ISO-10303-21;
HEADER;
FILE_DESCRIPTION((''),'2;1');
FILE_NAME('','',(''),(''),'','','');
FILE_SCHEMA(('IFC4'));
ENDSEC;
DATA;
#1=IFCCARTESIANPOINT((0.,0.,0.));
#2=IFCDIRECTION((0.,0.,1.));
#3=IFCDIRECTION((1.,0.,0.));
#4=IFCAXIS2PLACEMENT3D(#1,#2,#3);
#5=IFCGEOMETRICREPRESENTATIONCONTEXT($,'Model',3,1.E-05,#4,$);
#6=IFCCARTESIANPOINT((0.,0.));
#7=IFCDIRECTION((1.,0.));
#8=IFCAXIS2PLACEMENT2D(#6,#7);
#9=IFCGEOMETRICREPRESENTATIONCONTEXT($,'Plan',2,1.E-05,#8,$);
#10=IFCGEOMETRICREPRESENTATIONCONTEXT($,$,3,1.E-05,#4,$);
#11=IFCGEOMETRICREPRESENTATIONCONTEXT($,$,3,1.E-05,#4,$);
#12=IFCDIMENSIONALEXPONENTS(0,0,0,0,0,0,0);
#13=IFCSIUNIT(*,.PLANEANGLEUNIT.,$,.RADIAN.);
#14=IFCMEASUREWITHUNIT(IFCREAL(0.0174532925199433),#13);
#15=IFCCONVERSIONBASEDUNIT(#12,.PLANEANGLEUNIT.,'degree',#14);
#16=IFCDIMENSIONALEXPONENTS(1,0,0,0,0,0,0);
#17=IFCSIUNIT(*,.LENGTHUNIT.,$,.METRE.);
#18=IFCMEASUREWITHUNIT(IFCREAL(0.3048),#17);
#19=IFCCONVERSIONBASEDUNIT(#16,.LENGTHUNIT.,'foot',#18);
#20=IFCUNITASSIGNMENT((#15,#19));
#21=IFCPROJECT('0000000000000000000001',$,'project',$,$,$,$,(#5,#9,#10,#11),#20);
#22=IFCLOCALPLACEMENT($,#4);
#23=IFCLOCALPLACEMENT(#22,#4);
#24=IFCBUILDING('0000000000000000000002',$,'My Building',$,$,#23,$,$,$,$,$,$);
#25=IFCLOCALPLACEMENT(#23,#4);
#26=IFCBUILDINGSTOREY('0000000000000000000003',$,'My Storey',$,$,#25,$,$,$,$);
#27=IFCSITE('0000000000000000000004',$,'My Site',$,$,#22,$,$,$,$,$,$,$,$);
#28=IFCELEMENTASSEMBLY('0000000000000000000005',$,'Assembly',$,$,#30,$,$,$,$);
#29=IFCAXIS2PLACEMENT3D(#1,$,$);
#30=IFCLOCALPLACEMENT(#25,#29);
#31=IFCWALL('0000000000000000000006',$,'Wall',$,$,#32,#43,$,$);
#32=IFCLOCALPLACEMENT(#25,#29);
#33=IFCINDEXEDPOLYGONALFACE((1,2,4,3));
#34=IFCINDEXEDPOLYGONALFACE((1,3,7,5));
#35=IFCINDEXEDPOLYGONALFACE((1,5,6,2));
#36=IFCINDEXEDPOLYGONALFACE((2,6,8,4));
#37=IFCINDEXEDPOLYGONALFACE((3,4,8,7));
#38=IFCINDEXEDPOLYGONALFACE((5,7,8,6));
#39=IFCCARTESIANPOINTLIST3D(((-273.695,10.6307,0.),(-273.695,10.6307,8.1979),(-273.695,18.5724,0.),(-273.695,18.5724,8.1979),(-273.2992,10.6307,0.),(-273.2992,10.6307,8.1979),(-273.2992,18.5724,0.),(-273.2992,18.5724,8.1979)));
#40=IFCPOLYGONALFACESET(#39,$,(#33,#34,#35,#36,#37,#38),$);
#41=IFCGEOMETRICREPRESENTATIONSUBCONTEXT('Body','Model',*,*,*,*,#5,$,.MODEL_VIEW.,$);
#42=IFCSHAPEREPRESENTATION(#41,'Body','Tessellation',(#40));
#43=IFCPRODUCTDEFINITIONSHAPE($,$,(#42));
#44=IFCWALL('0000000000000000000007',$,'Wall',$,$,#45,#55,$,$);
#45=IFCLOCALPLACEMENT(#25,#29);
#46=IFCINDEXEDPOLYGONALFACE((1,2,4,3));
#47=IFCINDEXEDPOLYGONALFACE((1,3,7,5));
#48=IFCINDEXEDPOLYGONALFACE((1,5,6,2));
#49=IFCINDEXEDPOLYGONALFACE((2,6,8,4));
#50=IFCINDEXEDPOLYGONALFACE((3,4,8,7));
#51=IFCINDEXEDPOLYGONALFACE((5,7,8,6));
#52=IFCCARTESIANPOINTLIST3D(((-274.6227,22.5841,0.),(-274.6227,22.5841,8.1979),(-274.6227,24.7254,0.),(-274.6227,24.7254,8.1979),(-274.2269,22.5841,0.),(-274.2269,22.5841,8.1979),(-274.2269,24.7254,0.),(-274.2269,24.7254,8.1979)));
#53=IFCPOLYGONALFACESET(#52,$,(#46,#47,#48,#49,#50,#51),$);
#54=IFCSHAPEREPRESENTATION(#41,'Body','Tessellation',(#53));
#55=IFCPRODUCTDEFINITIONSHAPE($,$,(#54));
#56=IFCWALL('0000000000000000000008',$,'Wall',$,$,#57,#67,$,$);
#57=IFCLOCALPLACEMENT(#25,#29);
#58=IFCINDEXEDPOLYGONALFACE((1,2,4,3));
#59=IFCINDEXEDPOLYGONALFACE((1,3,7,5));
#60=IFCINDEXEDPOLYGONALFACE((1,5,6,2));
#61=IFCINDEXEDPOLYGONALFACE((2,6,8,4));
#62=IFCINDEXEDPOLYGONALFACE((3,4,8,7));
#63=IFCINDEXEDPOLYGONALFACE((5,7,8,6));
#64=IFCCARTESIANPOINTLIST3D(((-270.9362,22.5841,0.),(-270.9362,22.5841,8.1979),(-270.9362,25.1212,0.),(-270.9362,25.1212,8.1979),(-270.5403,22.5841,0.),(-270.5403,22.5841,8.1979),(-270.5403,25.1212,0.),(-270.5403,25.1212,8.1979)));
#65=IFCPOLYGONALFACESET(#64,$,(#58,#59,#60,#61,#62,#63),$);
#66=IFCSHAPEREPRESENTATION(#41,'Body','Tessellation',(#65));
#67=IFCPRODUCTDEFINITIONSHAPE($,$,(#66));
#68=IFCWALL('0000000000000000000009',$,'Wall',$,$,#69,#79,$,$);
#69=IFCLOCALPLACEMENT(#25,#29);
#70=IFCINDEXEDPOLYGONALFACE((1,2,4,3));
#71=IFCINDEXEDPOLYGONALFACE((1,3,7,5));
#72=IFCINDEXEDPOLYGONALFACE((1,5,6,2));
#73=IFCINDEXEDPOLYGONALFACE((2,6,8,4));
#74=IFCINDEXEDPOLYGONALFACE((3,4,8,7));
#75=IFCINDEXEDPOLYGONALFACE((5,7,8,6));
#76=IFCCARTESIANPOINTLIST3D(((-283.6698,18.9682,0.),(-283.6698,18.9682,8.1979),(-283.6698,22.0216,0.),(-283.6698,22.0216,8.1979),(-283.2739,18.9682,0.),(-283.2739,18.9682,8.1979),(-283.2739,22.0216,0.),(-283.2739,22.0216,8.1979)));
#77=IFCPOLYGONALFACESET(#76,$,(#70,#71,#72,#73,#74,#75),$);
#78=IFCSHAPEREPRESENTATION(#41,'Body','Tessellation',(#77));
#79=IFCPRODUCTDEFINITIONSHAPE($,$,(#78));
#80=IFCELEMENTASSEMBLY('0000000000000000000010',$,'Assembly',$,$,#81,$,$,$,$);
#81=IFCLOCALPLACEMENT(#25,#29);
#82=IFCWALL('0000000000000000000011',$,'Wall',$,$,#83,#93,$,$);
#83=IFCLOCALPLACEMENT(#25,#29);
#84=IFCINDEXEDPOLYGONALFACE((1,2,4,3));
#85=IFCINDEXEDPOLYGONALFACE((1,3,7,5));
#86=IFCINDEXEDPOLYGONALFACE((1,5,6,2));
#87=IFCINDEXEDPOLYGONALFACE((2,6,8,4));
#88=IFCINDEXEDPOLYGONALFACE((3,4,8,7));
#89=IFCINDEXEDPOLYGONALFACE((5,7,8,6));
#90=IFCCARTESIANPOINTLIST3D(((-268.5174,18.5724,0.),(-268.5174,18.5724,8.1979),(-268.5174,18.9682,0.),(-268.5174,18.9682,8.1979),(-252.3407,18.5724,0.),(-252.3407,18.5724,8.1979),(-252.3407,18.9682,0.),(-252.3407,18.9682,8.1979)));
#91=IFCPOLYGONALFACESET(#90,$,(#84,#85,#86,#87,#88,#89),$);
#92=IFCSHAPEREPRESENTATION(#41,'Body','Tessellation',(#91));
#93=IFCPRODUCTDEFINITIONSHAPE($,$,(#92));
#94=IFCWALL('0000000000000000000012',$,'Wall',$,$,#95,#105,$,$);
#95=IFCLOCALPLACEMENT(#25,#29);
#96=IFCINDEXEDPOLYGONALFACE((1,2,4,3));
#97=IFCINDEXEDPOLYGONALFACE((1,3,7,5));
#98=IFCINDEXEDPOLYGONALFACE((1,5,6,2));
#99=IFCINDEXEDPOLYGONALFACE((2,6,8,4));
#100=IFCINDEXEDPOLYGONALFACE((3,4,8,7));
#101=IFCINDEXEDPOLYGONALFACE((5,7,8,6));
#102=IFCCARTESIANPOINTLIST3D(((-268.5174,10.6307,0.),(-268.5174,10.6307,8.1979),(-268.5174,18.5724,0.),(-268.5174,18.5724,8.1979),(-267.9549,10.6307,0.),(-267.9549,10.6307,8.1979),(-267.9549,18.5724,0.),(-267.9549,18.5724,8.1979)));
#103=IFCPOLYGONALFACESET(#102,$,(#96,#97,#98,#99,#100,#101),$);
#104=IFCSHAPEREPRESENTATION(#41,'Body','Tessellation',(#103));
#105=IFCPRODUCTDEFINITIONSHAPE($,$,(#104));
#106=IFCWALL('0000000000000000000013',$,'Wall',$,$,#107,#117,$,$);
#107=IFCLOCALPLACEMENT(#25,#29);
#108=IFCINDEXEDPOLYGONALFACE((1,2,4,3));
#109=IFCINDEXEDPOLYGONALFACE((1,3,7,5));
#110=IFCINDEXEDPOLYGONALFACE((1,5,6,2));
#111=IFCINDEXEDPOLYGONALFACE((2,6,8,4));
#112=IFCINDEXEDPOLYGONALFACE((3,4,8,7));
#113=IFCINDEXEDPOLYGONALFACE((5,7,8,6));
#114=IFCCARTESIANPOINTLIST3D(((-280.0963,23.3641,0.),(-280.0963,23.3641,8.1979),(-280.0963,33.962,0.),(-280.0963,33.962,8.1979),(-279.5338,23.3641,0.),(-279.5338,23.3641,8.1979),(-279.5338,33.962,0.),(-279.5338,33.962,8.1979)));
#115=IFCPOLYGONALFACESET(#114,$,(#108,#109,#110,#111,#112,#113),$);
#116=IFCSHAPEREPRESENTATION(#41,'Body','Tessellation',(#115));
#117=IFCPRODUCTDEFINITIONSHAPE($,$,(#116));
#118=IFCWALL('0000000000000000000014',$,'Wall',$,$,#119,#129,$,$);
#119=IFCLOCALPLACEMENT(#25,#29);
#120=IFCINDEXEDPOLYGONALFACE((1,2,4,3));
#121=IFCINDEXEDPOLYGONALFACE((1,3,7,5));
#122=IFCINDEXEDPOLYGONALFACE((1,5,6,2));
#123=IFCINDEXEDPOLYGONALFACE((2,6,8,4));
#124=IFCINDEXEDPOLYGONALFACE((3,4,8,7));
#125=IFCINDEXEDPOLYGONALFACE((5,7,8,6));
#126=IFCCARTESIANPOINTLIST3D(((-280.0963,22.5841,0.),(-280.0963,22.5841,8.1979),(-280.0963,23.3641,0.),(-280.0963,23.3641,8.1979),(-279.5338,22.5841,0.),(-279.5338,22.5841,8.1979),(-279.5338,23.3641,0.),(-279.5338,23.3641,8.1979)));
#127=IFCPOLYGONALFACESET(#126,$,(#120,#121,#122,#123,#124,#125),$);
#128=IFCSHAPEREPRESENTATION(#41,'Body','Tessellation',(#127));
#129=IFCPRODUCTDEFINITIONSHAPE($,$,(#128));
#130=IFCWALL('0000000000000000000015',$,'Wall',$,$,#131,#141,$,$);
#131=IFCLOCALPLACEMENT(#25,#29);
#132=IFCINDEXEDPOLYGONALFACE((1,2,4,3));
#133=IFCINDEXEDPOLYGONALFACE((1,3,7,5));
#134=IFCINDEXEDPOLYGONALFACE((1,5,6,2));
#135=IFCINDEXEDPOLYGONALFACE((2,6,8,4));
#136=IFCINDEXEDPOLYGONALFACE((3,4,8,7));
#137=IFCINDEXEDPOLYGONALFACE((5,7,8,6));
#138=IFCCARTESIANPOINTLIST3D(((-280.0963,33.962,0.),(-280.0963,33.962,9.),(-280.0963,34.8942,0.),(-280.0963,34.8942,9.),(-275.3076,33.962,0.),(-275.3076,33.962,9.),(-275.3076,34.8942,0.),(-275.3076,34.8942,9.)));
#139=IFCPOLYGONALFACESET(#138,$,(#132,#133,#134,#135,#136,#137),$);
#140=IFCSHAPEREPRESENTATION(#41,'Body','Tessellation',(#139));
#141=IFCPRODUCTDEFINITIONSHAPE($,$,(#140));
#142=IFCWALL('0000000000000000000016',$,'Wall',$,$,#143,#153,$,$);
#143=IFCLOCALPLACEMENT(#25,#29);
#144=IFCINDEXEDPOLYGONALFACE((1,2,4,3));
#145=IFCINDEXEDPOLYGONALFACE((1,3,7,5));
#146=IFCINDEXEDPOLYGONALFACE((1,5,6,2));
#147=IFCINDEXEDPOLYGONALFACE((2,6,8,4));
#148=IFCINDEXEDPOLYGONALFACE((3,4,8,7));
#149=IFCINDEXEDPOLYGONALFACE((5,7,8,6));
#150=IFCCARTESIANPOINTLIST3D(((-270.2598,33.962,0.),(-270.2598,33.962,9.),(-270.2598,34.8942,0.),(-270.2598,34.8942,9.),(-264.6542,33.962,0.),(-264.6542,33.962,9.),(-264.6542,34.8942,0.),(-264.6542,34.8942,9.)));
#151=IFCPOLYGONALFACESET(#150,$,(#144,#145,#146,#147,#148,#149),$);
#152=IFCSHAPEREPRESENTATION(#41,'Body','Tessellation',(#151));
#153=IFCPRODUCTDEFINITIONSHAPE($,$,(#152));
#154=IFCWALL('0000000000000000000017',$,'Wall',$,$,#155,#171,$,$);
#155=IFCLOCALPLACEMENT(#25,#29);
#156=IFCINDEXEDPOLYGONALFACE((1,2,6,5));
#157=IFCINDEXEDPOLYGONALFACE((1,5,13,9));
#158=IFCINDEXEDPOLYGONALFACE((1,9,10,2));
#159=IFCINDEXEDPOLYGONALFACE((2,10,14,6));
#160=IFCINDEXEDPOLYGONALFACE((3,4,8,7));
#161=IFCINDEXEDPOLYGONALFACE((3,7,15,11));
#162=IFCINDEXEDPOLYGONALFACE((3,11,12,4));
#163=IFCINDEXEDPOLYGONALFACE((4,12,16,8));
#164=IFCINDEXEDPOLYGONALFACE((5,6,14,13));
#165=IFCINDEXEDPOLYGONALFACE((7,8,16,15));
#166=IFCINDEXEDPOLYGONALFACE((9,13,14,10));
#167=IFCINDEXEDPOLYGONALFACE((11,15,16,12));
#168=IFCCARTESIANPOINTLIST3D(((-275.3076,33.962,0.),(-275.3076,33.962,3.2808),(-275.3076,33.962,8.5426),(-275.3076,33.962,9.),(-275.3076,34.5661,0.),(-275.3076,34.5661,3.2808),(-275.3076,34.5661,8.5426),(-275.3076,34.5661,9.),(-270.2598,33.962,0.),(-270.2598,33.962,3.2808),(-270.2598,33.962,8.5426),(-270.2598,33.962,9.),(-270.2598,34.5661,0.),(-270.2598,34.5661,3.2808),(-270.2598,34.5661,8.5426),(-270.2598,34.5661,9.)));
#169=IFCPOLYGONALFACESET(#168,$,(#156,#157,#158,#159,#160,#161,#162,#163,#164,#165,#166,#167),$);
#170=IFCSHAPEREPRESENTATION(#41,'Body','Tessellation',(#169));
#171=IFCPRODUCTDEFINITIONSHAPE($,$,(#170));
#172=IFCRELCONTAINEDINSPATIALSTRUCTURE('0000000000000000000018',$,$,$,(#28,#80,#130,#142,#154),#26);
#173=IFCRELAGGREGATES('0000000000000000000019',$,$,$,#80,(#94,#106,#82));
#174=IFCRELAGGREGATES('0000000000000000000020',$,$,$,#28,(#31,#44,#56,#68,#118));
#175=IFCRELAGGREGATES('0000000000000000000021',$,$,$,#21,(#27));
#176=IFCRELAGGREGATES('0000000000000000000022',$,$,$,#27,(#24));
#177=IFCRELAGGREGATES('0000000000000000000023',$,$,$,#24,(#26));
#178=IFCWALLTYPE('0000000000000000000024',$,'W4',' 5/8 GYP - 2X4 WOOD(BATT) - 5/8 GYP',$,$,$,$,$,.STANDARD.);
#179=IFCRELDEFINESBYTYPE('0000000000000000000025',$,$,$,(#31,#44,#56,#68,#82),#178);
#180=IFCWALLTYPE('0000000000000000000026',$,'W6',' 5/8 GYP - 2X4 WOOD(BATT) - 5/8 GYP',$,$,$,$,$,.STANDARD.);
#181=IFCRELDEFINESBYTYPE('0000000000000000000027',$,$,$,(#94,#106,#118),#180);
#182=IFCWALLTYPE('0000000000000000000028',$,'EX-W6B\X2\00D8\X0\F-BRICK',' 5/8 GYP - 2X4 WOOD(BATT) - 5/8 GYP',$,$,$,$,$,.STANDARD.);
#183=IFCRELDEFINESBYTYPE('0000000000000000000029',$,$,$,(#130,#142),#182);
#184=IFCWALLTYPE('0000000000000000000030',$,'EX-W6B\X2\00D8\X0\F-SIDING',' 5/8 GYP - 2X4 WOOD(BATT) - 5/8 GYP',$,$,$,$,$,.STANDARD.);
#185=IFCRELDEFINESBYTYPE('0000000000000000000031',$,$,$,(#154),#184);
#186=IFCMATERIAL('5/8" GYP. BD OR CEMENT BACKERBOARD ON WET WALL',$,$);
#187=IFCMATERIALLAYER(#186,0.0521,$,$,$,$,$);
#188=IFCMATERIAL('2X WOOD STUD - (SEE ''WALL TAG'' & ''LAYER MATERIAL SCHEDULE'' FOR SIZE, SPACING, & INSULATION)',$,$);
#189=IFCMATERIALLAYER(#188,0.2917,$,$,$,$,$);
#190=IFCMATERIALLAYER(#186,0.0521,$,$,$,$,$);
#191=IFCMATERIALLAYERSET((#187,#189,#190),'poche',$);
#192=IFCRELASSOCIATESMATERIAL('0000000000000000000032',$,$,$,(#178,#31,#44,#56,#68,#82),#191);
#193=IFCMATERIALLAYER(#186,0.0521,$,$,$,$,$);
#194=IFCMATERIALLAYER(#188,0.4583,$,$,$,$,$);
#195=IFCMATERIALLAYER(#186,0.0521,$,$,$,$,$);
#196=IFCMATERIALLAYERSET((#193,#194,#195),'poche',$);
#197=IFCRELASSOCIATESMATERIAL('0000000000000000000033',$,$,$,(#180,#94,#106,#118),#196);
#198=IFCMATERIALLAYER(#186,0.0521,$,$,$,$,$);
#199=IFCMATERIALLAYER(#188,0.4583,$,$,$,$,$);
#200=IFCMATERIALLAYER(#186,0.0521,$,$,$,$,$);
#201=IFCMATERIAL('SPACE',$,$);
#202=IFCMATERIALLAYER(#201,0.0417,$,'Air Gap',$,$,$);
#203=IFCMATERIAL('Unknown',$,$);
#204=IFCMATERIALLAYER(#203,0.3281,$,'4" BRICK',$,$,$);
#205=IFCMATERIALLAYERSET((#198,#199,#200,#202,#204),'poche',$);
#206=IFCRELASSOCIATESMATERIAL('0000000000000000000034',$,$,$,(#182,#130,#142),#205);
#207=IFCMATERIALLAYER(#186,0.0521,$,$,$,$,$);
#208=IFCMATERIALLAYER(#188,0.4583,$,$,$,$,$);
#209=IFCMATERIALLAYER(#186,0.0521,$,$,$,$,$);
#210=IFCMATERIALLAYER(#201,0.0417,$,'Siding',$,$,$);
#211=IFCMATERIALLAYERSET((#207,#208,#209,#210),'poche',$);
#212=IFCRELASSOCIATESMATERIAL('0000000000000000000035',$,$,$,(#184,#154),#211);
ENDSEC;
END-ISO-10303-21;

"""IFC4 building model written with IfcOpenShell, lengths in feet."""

from ifc_helpers import new_model, entity, si_unit, converted_unit, frame, origin_with_axes, origin_2d_with_axis, place, context, subcontext, project, spatial, line, indexed_curve, outline, extrude, source, transform, mapped, material, layer, layer_set, layer_usage, type_object, element, aggregate, save


model = new_model("IFC4")

# Units and contexts
model_context = context("Model", 3, precision=1e-05, world=origin_with_axes())
plan_context = context("Plan", 2, precision=1e-05, world=origin_2d_with_axis())
context_of_model_1 = context(None, 3, precision=1e-05, world=origin_with_axes())
context_of_model_2 = context(None, 3, precision=1e-05, world=origin_with_axes())
body_context = subcontext(model_context, "Body", "Model", "MODEL_VIEW")
ifc_project = project(units=[converted_unit("PLANEANGLEUNIT", "degree", entity("IfcReal", 0.0174532925199433), si_unit("PLANEANGLEUNIT", "RADIAN"), dimensions=[0, 0, 0, 0, 0, 0, 0]), converted_unit("LENGTHUNIT", "foot", entity("IfcReal", 0.3048), si_unit("LENGTHUNIT", "METRE"), dimensions=[1, 0, 0, 0, 0, 0, 0])], contexts=[model_context, plan_context, context_of_model_1, context_of_model_2])

# Site, building, storey
site_placement = place(None, origin_with_axes())
site = spatial("IfcSite", under=ifc_project, at=site_placement, Name="My Site")
building_placement = place(site_placement, origin_with_axes())
building = spatial("IfcBuilding", under=site, at=building_placement, Name="My Building")
storey_placement = place(building_placement, origin_with_axes())
storey = spatial("IfcBuildingStorey", under=building, at=storey_placement, Name="My Storey")

# Element assembly, walls
assembly_1_placement = place(storey_placement, origin_with_axes())
assembly_1 = element("IfcElementAssembly", 1, at=assembly_1_placement, inside=storey, Name="Assembly")
ifc_material_1 = material(Name="5/8\" GYP. BD OR CEMENT BACKERBOARD ON WET WALL")
ifc_layer_1 = layer(ifc_material_1, 0.0521)
ifc_material_2 = material(Name="2X WOOD STUD - (SEE 'WALL TAG' & 'LAYER MATERIAL SCHEDULE' FOR SIZE, SPACING, & INSULATION)")
ifc_layer_2 = layer(ifc_material_2, 0.2917)
ifc_layer_3 = layer(ifc_material_1, 0.0521)
ifc_layer_set_1 = layer_set([ifc_layer_1, ifc_layer_2, ifc_layer_3], Name="poche")
ifc_layer_usage_1 = layer_usage(ifc_layer_set_1, "AXIS2", "POSITIVE", 0.0)
wall_type_1 = type_object("IfcWallType", Name="W4", Description=" 5/8 GYP - 2X4 WOOD(BATT) - 5/8 GYP", PredefinedType="STANDARD", material=ifc_layer_set_1)
wall_1_placement = place(assembly_1_placement, frame((-273.695, 18.5724, 0.0), z_axis=(0.0, 0.0, 1.0), x_axis=(0.0, -1.0, 0.0)))
wall_1 = element("IfcWall", 2, at=wall_1_placement, type_object=wall_type_1, material=ifc_layer_usage_1, Name="Wall", context=body_context, shape_type="SweptSolid", body=[
    extrude(outline(indexed_curve([(0.0, 0.0), (0.0, 0.3958), (7.9417, 0.3958), (7.9417, 0.0), (0.0, 0.0)], self_intersect=False)), origin_with_axes(), (0.0, 0.0, 1.0), 8.1979),
])
ifc_layer_usage_2 = layer_usage(ifc_layer_set_1, "AXIS2", "POSITIVE", 0.0)
wall_2_placement = place(assembly_1_placement, frame((-274.2269, 22.5841, 0.0), z_axis=(0.0, 0.0, 1.0), x_axis=(0.0, 1.0, 0.0)))
wall_2 = element("IfcWall", 3, at=wall_2_placement, type_object=wall_type_1, material=ifc_layer_usage_2, Name="Wall", context=body_context, shape_type="SweptSolid", body=[
    extrude(outline(indexed_curve([(0.0, 0.0), (0.0, 0.3958), (2.1413, 0.3958), (2.1413, 0.0), (0.0, 0.0)], self_intersect=False)), origin_with_axes(), (0.0, 0.0, 1.0), 8.1979),
])
ifc_layer_usage_3 = layer_usage(ifc_layer_set_1, "AXIS2", "POSITIVE", 0.0)
wall_3_placement = place(assembly_1_placement, frame((-270.9362, 25.1212, 0.0), z_axis=(0.0, 0.0, 1.0), x_axis=(0.0, -1.0, 0.0)))
wall_3 = element("IfcWall", 4, at=wall_3_placement, type_object=wall_type_1, material=ifc_layer_usage_3, Name="Wall", context=body_context, shape_type="SweptSolid", body=[
    extrude(outline(indexed_curve([(0.0, 0.0), (0.0, 0.3958), (2.5371, 0.3958), (2.5371, 0.0), (0.0, 0.0)], self_intersect=False)), origin_with_axes(), (0.0, 0.0, 1.0), 8.1979),
])
ifc_layer_usage_4 = layer_usage(ifc_layer_set_1, "AXIS2", "POSITIVE", 0.0)
wall_4_placement = place(assembly_1_placement, frame((-283.2739, 18.9682, 0.0), z_axis=(0.0, 0.0, 1.0), x_axis=(0.0, 1.0, 0.0)))
wall_4 = element("IfcWall", 5, at=wall_4_placement, type_object=wall_type_1, material=ifc_layer_usage_4, Name="Wall", context=body_context, shape_type="SweptSolid", body=[
    extrude(outline(indexed_curve([(0.0, 0.0), (0.0, 0.3958), (3.0533, 0.3958), (3.0533, 0.0), (0.0, 0.0)], self_intersect=False)), origin_with_axes(), (0.0, 0.0, 1.0), 8.1979),
])

# Element assembly, walls
assembly_2_placement = place(storey_placement, origin_with_axes())
assembly_2 = element("IfcElementAssembly", 6, at=assembly_2_placement, inside=storey, Name="Assembly")
ifc_layer_usage_5 = layer_usage(ifc_layer_set_1, "AXIS2", "POSITIVE", 0.0)
wall_5_placement = place(assembly_2_placement, frame((-268.5174, 18.5724, 0.0), z_axis=(0.0, 0.0, 1.0), x_axis=(1.0, 0.0, 0.0)))
wall_5 = element("IfcWall", 7, at=wall_5_placement, type_object=wall_type_1, material=ifc_layer_usage_5, Name="Wall", context=body_context, shape_type="SweptSolid", body=[
    extrude(outline(indexed_curve([(0.0, 0.0), (0.0, 0.3958), (16.1767, 0.3958), (16.1767, 0.0), (0.0, 0.0)], self_intersect=False)), origin_with_axes(), (0.0, 0.0, 1.0), 8.1979),
])
ifc_layer_4 = layer(ifc_material_1, 0.0521)
ifc_layer_5 = layer(ifc_material_2, 0.4583)
ifc_layer_6 = layer(ifc_material_1, 0.0521)
ifc_layer_set_2 = layer_set([ifc_layer_4, ifc_layer_5, ifc_layer_6], Name="poche")
ifc_layer_usage_6 = layer_usage(ifc_layer_set_2, "AXIS2", "POSITIVE", 0.0)
wall_type_2 = type_object("IfcWallType", Name="W6", Description=" 5/8 GYP - 2X4 WOOD(BATT) - 5/8 GYP", PredefinedType="STANDARD", material=ifc_layer_set_2)
wall_6_placement = place(assembly_2_placement, frame((-268.5174, 18.5724, 0.0), z_axis=(0.0, 0.0, 1.0), x_axis=(0.0, -1.0, 0.0)))
wall_6 = element("IfcWall", 8, at=wall_6_placement, type_object=wall_type_2, material=ifc_layer_usage_6, Name="Wall", context=body_context, shape_type="SweptSolid", body=[
    extrude(outline(indexed_curve([(0.0, 0.0), (0.0, 0.5625), (7.9417, 0.5625), (7.9417, 0.0), (0.0, 0.0)], self_intersect=False)), origin_with_axes(), (0.0, 0.0, 1.0), 8.1979),
])
ifc_layer_usage_7 = layer_usage(ifc_layer_set_2, "AXIS2", "POSITIVE", 0.0)
wall_7_placement = place(assembly_2_placement, frame((-280.0963, 33.962, 0.0), z_axis=(0.0, 0.0, 1.0), x_axis=(0.0, -1.0, 0.0)))
wall_7 = element("IfcWall", 9, at=wall_7_placement, type_object=wall_type_2, material=ifc_layer_usage_7, Name="Wall", context=body_context, shape_type="SweptSolid", body=[
    extrude(outline(indexed_curve([(0.0, 0.0), (0.0, 0.5625), (10.5979, 0.5625), (10.5979, 0.0), (0.0, 0.0)], self_intersect=False)), origin_with_axes(), (0.0, 0.0, 1.0), 8.1979),
])
aggregate(assembly_2, [wall_6, wall_7, wall_5])

# Wall
ifc_layer_usage_8 = layer_usage(ifc_layer_set_2, "AXIS2", "POSITIVE", 0.0)
wall_8_placement = place(assembly_1_placement, frame((-280.0963, 23.3641, 0.0), z_axis=(0.0, 0.0, 1.0), x_axis=(0.0, -1.0, 0.0)))
wall_8 = element("IfcWall", 10, at=wall_8_placement, type_object=wall_type_2, material=ifc_layer_usage_8, Name="Wall", context=body_context, shape_type="SweptSolid", body=[
    extrude(outline(indexed_curve([(0.0, 0.0), (0.0, 0.5625), (0.78, 0.5625), (0.78, 0.0), (0.0, 0.0)], self_intersect=False)), origin_with_axes(), (0.0, 0.0, 1.0), 8.1979),
])
aggregate(assembly_1, [wall_1, wall_2, wall_3, wall_4, wall_8])

# Walls
ifc_layer_7 = layer(ifc_material_1, 0.0521)
ifc_layer_8 = layer(ifc_material_2, 0.4583)
ifc_layer_9 = layer(ifc_material_1, 0.0521)
ifc_material_3 = material(Name="SPACE")
ifc_layer_10 = layer(ifc_material_3, 0.0417, Name="Air Gap")
ifc_material_4 = material(Name="Unknown")
ifc_layer_11 = layer(ifc_material_4, 0.3281, Name="4\" BRICK")
ifc_layer_set_3 = layer_set([ifc_layer_7, ifc_layer_8, ifc_layer_9, ifc_layer_10, ifc_layer_11], Name="poche")
ifc_layer_usage_9 = layer_usage(ifc_layer_set_3, "AXIS2", "POSITIVE", 0.0)
wall_type_3 = type_object("IfcWallType", Name="EX-W6BØF-BRICK", Description=" 5/8 GYP - 2X4 WOOD(BATT) - 5/8 GYP", PredefinedType="STANDARD", material=ifc_layer_set_3)
wall_9_placement = place(storey_placement, frame((-280.0963, 33.962, 0.0), z_axis=(0.0, 0.0, 1.0), x_axis=(1.0, 0.0, 0.0)))
element("IfcWall", 11, at=wall_9_placement, inside=storey, type_object=wall_type_3, material=ifc_layer_usage_9, Name="Wall", context=body_context, shape_type="SweptSolid", body=[
    extrude(outline(indexed_curve([(0.0, 0.0), (0.0, 0.9323), (4.7887, 0.9323), (4.7887, 0.0), (0.0, 0.0)], self_intersect=False)), origin_with_axes(), (0.0, 0.0, 1.0), 9.0),
])
ifc_layer_usage_10 = layer_usage(ifc_layer_set_3, "AXIS2", "POSITIVE", 0.0)
wall_10_placement = place(storey_placement, frame((-270.2598, 33.962, 0.0), z_axis=(0.0, 0.0, 1.0), x_axis=(1.0, 0.0, 0.0)))
element("IfcWall", 12, at=wall_10_placement, inside=storey, type_object=wall_type_3, material=ifc_layer_usage_10, Name="Wall", context=body_context, shape_type="SweptSolid", body=[
    extrude(outline(indexed_curve([(0.0, 0.0), (0.0, 0.9323), (5.6056, 0.9323), (5.6056, 0.0), (0.0, 0.0)], self_intersect=False)), origin_with_axes(), (0.0, 0.0, 1.0), 9.0),
])

# Wall, opening
ifc_layer_12 = layer(ifc_material_1, 0.0521)
ifc_layer_13 = layer(ifc_material_2, 0.4583)
ifc_layer_14 = layer(ifc_material_1, 0.0521)
ifc_layer_15 = layer(ifc_material_3, 0.0417, Name="Siding")
ifc_layer_set_4 = layer_set([ifc_layer_12, ifc_layer_13, ifc_layer_14, ifc_layer_15], Name="poche")
ifc_layer_usage_11 = layer_usage(ifc_layer_set_4, "AXIS2", "POSITIVE", 0.0)
wall_type_4 = type_object("IfcWallType", Name="EX-W6BØF-SIDING", Description=" 5/8 GYP - 2X4 WOOD(BATT) - 5/8 GYP", PredefinedType="STANDARD", material=ifc_layer_set_4)
wall_11_placement = place(storey_placement, frame((-275.3076, 33.962, 0.0), z_axis=(0.0, 0.0, 1.0), x_axis=(1.0, 0.0, 0.0)))
wall_11 = element("IfcWall", 13, at=wall_11_placement, inside=storey, type_object=wall_type_4, material=ifc_layer_usage_11, Name="Wall", context=body_context, shape_type="SweptSolid", body=[
    extrude(outline(indexed_curve([(0.0, 0.0), (0.0, 0.6042), (5.0478, 0.6042), (5.0478, 0.0), (0.0, 0.0)], self_intersect=False)), origin_with_axes(), (0.0, 0.0, 1.0), 9.0),
])
shared_shape_1 = source(origin_with_axes(), body_context, "Body", "SweptSolid", [
    extrude(outline(indexed_curve([(0.0, 0.0), (5.0478, 0.0), (5.0478, 5.2618), (0.0, 5.2618)], segments=[line(1, 2, 3, 4, 1)])), frame((0.0, -0.3281, 0.0), z_axis=(0.0, -1.0, 0.0), x_axis=(1.0, 0.0, 0.0)), (0.0, 0.0, -1.0), 1.2603),
])
opening_1_placement = place(wall_11_placement, frame((0.0, 0.0, 3.2808), z_axis=(0.0, 0.0, 1.0), x_axis=(1.0, 0.0, 0.0)))
element("IfcOpeningElement", 14, at=opening_1_placement, cuts=wall_11, PredefinedType="OPENING", context=body_context, shape_type="MappedRepresentation", body=[
    mapped(shared_shape_1, transform((0.0, 0.0, 0.0), x_axis=(1.0, 0.0, 0.0), y_axis=(0.0, 1.0, 0.0), z_axis=(0.0, 0.0, 1.0), scale=1.0)),
])

save(model, "model.ifc")
